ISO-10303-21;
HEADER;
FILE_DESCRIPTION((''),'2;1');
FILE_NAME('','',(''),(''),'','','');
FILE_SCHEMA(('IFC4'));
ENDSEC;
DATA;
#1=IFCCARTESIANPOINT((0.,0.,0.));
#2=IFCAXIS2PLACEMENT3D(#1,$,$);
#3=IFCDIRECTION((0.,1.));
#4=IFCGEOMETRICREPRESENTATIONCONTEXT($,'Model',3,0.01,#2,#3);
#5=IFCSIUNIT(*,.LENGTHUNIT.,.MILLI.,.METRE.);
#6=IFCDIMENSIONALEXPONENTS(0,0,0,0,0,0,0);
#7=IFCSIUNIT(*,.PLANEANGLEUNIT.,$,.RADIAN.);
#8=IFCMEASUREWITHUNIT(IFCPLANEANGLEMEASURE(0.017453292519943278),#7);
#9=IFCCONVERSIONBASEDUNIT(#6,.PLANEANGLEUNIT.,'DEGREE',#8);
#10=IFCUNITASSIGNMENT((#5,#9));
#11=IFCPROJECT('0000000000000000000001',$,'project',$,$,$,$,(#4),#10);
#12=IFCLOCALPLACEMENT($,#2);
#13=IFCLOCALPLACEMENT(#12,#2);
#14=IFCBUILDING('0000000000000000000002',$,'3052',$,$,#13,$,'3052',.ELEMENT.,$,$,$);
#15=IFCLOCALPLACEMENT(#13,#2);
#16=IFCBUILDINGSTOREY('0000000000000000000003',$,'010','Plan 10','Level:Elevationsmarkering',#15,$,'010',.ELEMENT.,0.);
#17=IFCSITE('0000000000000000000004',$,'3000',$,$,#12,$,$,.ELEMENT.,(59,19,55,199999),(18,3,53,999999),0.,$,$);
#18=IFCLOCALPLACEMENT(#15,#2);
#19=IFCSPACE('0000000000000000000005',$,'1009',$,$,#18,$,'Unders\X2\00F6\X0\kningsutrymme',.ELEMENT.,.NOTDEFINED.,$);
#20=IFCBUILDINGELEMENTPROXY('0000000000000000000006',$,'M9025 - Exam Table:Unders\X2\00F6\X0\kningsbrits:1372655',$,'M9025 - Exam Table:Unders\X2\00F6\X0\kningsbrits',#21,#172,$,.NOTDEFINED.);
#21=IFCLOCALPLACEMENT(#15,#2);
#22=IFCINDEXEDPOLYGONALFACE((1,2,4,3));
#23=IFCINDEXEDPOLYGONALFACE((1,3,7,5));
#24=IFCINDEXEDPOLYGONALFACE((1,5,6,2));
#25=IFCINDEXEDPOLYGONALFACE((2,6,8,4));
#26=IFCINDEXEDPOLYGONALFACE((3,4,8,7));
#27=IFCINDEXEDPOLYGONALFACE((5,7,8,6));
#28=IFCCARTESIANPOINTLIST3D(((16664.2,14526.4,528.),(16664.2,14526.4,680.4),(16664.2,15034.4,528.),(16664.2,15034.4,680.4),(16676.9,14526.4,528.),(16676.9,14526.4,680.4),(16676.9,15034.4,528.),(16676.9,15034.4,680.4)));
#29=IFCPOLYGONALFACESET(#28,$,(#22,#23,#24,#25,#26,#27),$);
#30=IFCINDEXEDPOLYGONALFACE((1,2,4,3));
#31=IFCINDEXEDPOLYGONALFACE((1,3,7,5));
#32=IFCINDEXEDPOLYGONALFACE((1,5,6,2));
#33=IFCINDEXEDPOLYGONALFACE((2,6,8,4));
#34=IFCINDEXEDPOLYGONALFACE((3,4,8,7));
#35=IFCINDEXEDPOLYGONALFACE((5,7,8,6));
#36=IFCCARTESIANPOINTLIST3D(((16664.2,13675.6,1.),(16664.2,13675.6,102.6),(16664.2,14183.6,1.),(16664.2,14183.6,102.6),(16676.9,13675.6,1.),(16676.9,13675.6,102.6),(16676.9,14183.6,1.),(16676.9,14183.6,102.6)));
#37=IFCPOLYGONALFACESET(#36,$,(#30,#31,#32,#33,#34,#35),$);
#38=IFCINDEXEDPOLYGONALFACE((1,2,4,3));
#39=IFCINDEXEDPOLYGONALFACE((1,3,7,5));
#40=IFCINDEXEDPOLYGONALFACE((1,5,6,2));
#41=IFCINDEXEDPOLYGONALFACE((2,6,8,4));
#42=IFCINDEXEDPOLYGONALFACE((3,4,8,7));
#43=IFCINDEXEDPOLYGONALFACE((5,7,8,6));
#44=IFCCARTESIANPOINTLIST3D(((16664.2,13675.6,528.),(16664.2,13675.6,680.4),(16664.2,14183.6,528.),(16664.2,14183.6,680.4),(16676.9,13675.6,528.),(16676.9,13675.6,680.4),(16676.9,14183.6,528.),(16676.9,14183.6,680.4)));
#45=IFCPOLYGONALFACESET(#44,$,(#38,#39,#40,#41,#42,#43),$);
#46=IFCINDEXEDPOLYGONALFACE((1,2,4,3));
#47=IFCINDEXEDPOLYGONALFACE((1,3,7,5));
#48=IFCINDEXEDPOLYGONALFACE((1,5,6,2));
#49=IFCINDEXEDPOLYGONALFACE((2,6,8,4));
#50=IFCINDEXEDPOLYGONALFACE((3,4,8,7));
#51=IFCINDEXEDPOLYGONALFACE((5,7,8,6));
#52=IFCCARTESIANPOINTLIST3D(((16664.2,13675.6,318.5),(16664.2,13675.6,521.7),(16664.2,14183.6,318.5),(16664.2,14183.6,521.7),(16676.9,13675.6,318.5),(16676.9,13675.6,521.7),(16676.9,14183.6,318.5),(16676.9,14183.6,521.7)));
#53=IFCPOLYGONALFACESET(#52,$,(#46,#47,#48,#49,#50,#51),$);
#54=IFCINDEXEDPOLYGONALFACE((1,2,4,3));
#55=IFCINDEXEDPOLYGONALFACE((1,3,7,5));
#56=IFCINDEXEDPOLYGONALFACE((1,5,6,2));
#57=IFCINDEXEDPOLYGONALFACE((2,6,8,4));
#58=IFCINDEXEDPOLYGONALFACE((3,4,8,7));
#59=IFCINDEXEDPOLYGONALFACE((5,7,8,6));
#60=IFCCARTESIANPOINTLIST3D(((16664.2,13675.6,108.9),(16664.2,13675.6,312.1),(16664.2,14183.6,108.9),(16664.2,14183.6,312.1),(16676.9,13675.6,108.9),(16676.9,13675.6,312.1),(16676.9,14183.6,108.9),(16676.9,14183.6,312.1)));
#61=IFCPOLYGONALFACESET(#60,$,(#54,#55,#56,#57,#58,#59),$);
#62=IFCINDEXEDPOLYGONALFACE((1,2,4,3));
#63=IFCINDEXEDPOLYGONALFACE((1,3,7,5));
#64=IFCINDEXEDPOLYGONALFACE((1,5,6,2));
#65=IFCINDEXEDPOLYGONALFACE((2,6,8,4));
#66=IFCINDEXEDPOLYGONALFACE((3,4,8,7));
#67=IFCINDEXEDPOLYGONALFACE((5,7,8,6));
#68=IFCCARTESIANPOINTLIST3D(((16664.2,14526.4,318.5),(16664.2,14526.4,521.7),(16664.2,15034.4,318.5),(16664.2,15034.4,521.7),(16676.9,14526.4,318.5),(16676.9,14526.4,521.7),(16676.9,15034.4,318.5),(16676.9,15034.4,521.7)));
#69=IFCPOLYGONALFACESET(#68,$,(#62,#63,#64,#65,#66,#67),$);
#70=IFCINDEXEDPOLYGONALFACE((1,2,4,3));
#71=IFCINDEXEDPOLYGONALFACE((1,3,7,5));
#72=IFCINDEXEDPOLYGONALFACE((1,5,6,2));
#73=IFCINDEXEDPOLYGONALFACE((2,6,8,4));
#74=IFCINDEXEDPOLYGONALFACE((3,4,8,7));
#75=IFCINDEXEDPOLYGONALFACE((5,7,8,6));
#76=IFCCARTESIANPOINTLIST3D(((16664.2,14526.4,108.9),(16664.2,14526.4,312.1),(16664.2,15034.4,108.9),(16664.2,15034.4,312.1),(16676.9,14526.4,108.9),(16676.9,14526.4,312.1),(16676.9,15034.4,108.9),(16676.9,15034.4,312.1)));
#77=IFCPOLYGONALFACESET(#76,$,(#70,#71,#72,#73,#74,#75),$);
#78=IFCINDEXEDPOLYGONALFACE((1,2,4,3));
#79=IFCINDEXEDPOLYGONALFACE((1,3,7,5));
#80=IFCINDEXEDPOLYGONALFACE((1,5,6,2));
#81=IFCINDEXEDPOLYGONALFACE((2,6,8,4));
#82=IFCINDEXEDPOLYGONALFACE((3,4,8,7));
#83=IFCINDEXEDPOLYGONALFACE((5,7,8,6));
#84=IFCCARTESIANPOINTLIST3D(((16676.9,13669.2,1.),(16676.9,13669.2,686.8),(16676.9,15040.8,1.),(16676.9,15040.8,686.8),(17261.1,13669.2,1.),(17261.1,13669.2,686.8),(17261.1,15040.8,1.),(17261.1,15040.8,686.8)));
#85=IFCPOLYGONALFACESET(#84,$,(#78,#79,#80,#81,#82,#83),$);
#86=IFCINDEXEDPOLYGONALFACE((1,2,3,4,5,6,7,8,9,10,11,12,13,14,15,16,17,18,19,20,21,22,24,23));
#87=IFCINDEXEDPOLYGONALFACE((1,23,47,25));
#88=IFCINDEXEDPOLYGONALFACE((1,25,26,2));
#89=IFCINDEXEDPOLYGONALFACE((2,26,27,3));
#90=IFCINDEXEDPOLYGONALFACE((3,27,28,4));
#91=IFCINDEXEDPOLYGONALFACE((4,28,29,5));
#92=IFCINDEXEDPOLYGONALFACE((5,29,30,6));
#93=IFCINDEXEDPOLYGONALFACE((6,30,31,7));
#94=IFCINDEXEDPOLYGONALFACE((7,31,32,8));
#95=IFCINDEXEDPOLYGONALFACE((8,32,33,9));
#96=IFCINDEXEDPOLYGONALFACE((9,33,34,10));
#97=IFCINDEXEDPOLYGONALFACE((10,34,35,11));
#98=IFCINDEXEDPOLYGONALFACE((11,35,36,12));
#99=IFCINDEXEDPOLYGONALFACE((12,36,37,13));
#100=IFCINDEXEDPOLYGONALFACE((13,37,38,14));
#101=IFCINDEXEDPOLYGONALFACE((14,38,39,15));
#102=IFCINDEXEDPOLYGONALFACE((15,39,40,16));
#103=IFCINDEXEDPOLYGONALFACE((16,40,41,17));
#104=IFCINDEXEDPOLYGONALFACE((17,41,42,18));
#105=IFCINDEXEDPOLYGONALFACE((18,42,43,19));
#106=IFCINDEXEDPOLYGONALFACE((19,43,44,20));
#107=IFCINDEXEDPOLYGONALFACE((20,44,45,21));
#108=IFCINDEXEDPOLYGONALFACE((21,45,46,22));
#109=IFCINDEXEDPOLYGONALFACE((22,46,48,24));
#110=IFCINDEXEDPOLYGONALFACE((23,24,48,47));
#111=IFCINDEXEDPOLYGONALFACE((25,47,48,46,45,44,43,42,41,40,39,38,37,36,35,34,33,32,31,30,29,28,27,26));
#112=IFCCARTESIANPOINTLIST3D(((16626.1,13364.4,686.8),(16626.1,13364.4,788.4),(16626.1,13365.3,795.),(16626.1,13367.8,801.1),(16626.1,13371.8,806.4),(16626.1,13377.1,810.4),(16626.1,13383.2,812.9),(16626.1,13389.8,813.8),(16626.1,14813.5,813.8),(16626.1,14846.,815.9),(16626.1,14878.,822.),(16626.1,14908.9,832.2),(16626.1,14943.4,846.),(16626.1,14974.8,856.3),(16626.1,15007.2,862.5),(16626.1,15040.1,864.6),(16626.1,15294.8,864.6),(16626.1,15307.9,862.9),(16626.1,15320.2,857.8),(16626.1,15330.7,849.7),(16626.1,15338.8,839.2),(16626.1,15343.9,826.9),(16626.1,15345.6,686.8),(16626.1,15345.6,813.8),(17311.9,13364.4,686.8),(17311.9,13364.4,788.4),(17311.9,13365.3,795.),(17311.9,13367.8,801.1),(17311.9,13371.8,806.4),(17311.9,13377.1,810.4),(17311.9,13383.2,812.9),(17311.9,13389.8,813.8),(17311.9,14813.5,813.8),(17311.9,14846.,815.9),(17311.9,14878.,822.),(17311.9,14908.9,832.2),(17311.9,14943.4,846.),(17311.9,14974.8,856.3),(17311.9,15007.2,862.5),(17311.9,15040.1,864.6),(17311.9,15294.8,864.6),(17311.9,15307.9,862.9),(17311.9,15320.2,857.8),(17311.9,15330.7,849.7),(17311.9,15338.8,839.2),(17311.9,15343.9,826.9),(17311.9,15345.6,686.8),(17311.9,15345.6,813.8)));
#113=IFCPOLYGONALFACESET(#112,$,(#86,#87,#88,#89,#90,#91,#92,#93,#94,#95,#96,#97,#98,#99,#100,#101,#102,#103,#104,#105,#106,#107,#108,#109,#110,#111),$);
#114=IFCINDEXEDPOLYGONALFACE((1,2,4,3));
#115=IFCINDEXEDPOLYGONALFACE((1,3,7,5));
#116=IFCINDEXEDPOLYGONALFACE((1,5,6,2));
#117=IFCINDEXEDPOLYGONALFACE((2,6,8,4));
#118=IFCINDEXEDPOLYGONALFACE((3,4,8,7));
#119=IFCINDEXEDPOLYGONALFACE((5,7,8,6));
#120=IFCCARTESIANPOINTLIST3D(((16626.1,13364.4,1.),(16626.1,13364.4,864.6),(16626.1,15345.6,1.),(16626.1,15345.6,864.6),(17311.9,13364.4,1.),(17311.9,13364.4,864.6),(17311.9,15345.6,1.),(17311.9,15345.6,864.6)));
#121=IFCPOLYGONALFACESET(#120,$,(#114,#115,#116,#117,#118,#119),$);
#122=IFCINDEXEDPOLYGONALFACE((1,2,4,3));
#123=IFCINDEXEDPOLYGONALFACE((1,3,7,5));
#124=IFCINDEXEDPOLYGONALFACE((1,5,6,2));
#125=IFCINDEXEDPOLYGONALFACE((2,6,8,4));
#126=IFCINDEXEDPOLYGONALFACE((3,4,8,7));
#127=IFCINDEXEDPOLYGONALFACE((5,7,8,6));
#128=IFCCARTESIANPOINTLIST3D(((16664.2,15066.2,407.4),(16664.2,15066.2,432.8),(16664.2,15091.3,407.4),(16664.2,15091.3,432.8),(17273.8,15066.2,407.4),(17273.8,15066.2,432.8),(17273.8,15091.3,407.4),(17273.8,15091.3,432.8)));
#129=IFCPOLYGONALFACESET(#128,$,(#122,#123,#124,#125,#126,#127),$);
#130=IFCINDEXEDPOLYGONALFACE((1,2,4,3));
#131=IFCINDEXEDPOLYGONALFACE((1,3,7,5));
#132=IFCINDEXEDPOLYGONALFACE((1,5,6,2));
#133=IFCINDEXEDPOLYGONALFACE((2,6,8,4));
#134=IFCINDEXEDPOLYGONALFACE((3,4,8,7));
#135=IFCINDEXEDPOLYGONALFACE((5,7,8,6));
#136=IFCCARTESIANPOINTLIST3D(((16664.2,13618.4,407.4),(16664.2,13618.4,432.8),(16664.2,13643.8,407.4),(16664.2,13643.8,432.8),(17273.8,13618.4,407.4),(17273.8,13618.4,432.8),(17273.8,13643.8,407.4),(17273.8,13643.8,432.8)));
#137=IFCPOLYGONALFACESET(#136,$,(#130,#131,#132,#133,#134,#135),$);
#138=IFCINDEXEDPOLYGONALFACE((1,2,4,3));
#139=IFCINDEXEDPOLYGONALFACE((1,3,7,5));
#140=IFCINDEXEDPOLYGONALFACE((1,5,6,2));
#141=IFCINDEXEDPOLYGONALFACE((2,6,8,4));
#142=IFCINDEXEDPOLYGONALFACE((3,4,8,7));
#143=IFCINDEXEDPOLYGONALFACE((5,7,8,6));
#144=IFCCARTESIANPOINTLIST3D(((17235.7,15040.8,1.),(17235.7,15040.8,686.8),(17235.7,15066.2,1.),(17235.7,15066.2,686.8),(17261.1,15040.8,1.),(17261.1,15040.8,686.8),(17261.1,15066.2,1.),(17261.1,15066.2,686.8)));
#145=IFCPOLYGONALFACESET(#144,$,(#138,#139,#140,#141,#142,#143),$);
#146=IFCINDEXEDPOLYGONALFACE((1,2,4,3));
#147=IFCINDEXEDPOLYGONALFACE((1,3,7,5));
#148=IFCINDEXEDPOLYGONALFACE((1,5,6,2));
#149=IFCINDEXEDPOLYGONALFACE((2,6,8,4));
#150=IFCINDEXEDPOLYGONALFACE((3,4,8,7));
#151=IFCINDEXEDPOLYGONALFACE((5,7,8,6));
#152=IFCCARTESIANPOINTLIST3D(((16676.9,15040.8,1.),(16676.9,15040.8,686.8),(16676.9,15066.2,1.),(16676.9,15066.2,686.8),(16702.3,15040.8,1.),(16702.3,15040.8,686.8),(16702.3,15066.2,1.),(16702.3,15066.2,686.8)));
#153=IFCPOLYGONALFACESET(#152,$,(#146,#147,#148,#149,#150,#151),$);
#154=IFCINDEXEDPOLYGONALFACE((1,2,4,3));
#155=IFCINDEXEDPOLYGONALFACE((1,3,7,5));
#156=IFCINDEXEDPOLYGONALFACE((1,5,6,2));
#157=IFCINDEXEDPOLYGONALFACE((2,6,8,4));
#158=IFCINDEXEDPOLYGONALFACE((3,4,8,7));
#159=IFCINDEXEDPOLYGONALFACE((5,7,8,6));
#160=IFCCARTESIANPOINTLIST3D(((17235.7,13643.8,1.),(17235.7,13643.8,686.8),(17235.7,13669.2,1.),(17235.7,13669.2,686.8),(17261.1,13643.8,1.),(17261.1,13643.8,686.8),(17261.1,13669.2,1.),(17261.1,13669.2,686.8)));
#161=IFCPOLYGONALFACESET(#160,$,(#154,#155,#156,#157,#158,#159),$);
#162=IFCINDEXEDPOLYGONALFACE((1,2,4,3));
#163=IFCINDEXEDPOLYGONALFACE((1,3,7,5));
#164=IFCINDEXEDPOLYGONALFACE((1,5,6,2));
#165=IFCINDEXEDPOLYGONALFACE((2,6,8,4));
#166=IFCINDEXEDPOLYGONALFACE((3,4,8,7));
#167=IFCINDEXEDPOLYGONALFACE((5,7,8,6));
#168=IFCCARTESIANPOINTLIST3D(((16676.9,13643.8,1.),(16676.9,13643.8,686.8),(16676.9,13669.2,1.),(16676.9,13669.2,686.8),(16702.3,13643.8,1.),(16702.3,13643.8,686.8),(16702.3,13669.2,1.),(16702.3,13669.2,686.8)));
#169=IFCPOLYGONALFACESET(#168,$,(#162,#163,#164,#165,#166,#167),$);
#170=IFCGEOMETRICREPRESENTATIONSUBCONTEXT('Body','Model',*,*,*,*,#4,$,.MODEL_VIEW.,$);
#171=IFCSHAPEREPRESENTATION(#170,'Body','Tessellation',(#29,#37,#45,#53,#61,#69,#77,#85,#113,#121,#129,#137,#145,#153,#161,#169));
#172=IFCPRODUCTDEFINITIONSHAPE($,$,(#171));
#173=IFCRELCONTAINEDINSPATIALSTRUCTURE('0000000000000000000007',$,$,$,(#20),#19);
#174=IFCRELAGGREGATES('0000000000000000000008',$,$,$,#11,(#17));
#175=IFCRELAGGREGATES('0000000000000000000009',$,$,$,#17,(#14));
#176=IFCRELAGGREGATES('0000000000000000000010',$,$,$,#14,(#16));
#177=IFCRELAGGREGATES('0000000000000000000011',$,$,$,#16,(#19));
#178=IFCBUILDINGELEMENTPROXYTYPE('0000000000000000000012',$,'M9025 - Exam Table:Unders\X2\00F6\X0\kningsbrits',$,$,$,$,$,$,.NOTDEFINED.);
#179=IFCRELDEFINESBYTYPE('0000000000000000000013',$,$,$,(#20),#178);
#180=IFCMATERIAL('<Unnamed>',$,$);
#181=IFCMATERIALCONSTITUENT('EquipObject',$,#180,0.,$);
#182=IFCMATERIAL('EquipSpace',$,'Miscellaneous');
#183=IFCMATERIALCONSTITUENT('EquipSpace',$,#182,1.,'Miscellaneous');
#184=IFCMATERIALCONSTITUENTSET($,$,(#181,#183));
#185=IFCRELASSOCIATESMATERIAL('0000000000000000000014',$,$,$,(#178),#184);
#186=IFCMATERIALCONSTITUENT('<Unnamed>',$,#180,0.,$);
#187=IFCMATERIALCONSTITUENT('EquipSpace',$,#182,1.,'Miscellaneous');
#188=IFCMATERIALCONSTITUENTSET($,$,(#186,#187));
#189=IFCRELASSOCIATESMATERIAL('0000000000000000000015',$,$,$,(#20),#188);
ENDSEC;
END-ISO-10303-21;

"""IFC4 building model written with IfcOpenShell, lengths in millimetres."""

from ifc_helpers import new_model, entity, si_unit, converted_unit, direction, frame, origin, place, context, subcontext, project, spatial, line, arc, indexed_curve, outline, extrude, source, transform, mapped, material, constituent, constituent_set, type_object, type_shapes, element, save


model = new_model("IFC4")

# Units and contexts
model_context = context("Model", 3, precision=0.01, world=origin(), true_north=direction((0.0, 1.0)))
body_context = subcontext(model_context, "Body", "Model", "MODEL_VIEW")
ifc_project = project(units=[si_unit("LENGTHUNIT", "METRE", prefix="MILLI"), converted_unit("PLANEANGLEUNIT", "DEGREE", entity("IfcPlaneAngleMeasure", 0.017453292519943278), si_unit("PLANEANGLEUNIT", "RADIAN"), dimensions=[0, 0, 0, 0, 0, 0, 0])], contexts=[model_context])

# Site, building, storey
site_placement = place(None, origin())
site = spatial("IfcSite", under=ifc_project, at=site_placement, Name="3000", CompositionType="ELEMENT", RefLatitude=(59, 19, 55, 199999), RefLongitude=(18, 3, 53, 999999), RefElevation=0.0)
building_placement = place(site_placement, origin())
building = spatial("IfcBuilding", under=site, at=building_placement, Name="3052", LongName="3052", CompositionType="ELEMENT")
storey_placement = place(building_placement, origin())
storey = spatial("IfcBuildingStorey", under=building, at=storey_placement, Name="010", Description="Plan 10", ObjectType="Level:Elevationsmarkering", LongName="010", CompositionType="ELEMENT", Elevation=0.0)

# Shared definitions
ifc_material_1 = material(Name="<Unnamed>")
ifc_material_2 = material(Name="EquipSpace", Category="Miscellaneous")
ifc_constituent_1 = constituent(ifc_material_1, Name="EquipObject", fraction=0.0)
ifc_constituent_2 = constituent(ifc_material_2, Name="EquipSpace", Category="Miscellaneous", fraction=1.0)
ifc_constituent_set_1 = constituent_set(constituents=[ifc_constituent_1, ifc_constituent_2])
building_element_proxy_type = type_object("IfcBuildingElementProxyType", Name="M9025 - Exam Table:Undersökningsbrits", PredefinedType="NOTDEFINED", material=ifc_constituent_set_1)
shared_shape_1 = source(origin(), body_context, "Body", "SweptSolid", [
    extrude(outline(indexed_curve([(-6.3, -254.0), (6.3, -254.0), (6.3, 254.0), (-6.3, 254.0), (-6.3, -254.0)], self_intersect=False)), frame((-298.4, 425.4, 527.0), z_axis=(0.0, 0.0, 1.0), x_axis=(-1.0, 0.0, 0.0)), (0.0, 0.0, 1.0), 152.4),
    extrude(outline(indexed_curve([(-6.3, -254.0), (6.3, -254.0), (6.3, 254.0), (-6.3, 254.0), (-6.3, -254.0)], self_intersect=False)), frame((-298.4, -425.4, 0.0), z_axis=(0.0, 0.0, 1.0), x_axis=(-1.0, 0.0, 0.0)), (0.0, 0.0, 1.0), 101.6),
    extrude(outline(indexed_curve([(-6.3, -254.0), (6.3, -254.0), (6.3, 254.0), (-6.3, 254.0), (-6.3, -254.0)], self_intersect=False)), frame((-298.4, -425.4, 527.0), z_axis=(0.0, 0.0, 1.0), x_axis=(-1.0, 0.0, 0.0)), (0.0, 0.0, 1.0), 152.4),
    extrude(outline(indexed_curve([(-6.3, -254.0), (6.3, -254.0), (6.3, 254.0), (-6.3, 254.0), (-6.3, -254.0)], self_intersect=False)), frame((-298.4, -425.4, 317.5), z_axis=(0.0, 0.0, 1.0), x_axis=(-1.0, 0.0, 0.0)), (0.0, 0.0, 1.0), 203.2),
    extrude(outline(indexed_curve([(-6.3, -254.0), (6.3, -254.0), (6.3, 254.0), (-6.3, 254.0), (-6.3, -254.0)], self_intersect=False)), frame((-298.4, -425.4, 107.9), z_axis=(0.0, 0.0, 1.0), x_axis=(-1.0, 0.0, 0.0)), (0.0, 0.0, 1.0), 203.2),
    extrude(outline(indexed_curve([(-6.3, -254.0), (6.3, -254.0), (6.3, 254.0), (-6.3, 254.0), (-6.3, -254.0)], self_intersect=False)), frame((-298.4, 425.4, 317.5), z_axis=(0.0, 0.0, 1.0), x_axis=(-1.0, 0.0, 0.0)), (0.0, 0.0, 1.0), 203.2),
    extrude(outline(indexed_curve([(-6.3, -254.0), (6.3, -254.0), (6.3, 254.0), (-6.3, 254.0), (-6.3, -254.0)], self_intersect=False)), frame((-298.4, 425.4, 107.9), z_axis=(0.0, 0.0, 1.0), x_axis=(-1.0, 0.0, 0.0)), (0.0, 0.0, 1.0), 203.2),
    extrude(outline(indexed_curve([(-292.1, -685.8), (292.1, -685.8), (292.1, 685.8), (-292.1, 685.8), (-292.1, -685.8)], self_intersect=False)), frame((0.0, 0.0, 0.0), z_axis=(0.0, 0.0, 1.0), x_axis=(-1.0, 0.0, 0.0)), (0.0, 0.0, 1.0), 685.8),
    extrude(outline(indexed_curve([(-114.3, -764.5), (12.7, -764.5), (48.6, -749.7), (63.5, -713.7), (63.5, -459.1), (58.8, -409.8), (44.9, -362.4), (31.1, -327.9), (17.4, -281.0), (12.7, -232.5), (12.7, 1191.3), (5.3, 1209.2), (-12.7, 1216.7), (-114.3, 1216.7)], segments=[line(1, 2), arc(2, 3, 4), line(4, 5), arc(5, 6, 7), line(7, 8), arc(8, 9, 10), line(10, 11), arc(11, 12, 13), line(13, 14, 1)], self_intersect=False)), frame((-342.9, 226.1, 800.1), z_axis=(1.0, 0.0, 0.0), x_axis=(0.0, 0.0, 1.0)), (0.0, 0.0, 1.0), 685.8),
    extrude(outline(indexed_curve([(-342.9, -990.6), (342.9, -990.6), (342.9, 990.6), (-342.9, 990.6), (-342.9, -990.6)], self_intersect=False)), frame((0.0, 0.0, 0.0), z_axis=(0.0, 0.0, 1.0), x_axis=(-1.0, 0.0, 0.0)), (0.0, 0.0, 1.0), 863.6),
    extrude(outline(indexed_curve([(-304.8, -12.5), (304.8, -12.5), (304.8, 12.5), (-304.8, 12.5), (-304.8, -12.5)], self_intersect=False)), frame((0.0, 723.7, 406.4), z_axis=(0.0, 0.0, 1.0), x_axis=(-1.0, 0.0, 0.0)), (0.0, 0.0, 1.0), 25.4),
    extrude(outline(indexed_curve([(-304.8, -12.7), (304.8, -12.7), (304.8, 12.7), (-304.8, 12.7), (-304.8, -12.7)], self_intersect=False)), frame((0.0, -723.9, 406.4), z_axis=(0.0, 0.0, 1.0), x_axis=(-1.0, 0.0, 0.0)), (0.0, 0.0, 1.0), 25.4),
    extrude(outline(indexed_curve([(-12.7, -12.7), (12.7, -12.7), (12.7, 12.7), (-12.7, 12.7), (-12.7, -12.7)], self_intersect=False)), frame((279.4, 698.5, 0.0), z_axis=(0.0, 0.0, 1.0), x_axis=(0.0, 1.0, 0.0)), (0.0, 0.0, 1.0), 685.8),
    extrude(outline(indexed_curve([(-12.7, -12.7), (12.7, -12.7), (12.7, 12.7), (-12.7, 12.7), (-12.7, -12.7)], self_intersect=False)), frame((-279.4, 698.5, 0.0)), (0.0, 0.0, 1.0), 685.8),
    extrude(outline(indexed_curve([(-12.7, -12.7), (12.7, -12.7), (12.7, 12.7), (-12.7, 12.7), (-12.7, -12.7)], self_intersect=False)), frame((279.4, -698.5, 0.0), z_axis=(0.0, 0.0, 1.0), x_axis=(-1.0, 0.0, 0.0)), (0.0, 0.0, 1.0), 685.8),
    extrude(outline(indexed_curve([(-12.7, -12.7), (12.7, -12.7), (12.7, 12.7), (-12.7, 12.7), (-12.7, -12.7)], self_intersect=False)), frame((-279.4, -698.5, 0.0), z_axis=(0.0, 0.0, 1.0), x_axis=(0.0, -1.0, 0.0)), (0.0, 0.0, 1.0), 685.8),
])
type_shapes(building_element_proxy_type, [shared_shape_1])

# Shared definitions
space_1_placement = place(storey_placement, origin())
space_1 = spatial("IfcSpace", under=storey, at=space_1_placement, Name="1009", LongName="Undersökningsutrymme", CompositionType="ELEMENT", PredefinedType="NOTDEFINED")

# Building element proxy
ifc_constituent_3 = constituent(ifc_material_1, Name="<Unnamed>", fraction=0.0)
ifc_constituent_4 = constituent(ifc_material_2, Name="EquipSpace", Category="Miscellaneous", fraction=1.0)
ifc_constituent_set_2 = constituent_set(constituents=[ifc_constituent_3, ifc_constituent_4])
proxy_1_placement = place(space_1_placement, frame((16969.0, 14355.0, 1.0)))
element("IfcBuildingElementProxy", 1, at=proxy_1_placement, inside=space_1, type_object=building_element_proxy_type, material=ifc_constituent_set_2, Name="M9025 - Exam Table:Undersökningsbrits:1372655", ObjectType="M9025 - Exam Table:Undersökningsbrits", PredefinedType="NOTDEFINED", context=body_context, shape_type="MappedRepresentation", body=[
    mapped(shared_shape_1, transform((0.0, 0.0, 0.0), scale=1.0)),
])

save(model, "model.ifc")
